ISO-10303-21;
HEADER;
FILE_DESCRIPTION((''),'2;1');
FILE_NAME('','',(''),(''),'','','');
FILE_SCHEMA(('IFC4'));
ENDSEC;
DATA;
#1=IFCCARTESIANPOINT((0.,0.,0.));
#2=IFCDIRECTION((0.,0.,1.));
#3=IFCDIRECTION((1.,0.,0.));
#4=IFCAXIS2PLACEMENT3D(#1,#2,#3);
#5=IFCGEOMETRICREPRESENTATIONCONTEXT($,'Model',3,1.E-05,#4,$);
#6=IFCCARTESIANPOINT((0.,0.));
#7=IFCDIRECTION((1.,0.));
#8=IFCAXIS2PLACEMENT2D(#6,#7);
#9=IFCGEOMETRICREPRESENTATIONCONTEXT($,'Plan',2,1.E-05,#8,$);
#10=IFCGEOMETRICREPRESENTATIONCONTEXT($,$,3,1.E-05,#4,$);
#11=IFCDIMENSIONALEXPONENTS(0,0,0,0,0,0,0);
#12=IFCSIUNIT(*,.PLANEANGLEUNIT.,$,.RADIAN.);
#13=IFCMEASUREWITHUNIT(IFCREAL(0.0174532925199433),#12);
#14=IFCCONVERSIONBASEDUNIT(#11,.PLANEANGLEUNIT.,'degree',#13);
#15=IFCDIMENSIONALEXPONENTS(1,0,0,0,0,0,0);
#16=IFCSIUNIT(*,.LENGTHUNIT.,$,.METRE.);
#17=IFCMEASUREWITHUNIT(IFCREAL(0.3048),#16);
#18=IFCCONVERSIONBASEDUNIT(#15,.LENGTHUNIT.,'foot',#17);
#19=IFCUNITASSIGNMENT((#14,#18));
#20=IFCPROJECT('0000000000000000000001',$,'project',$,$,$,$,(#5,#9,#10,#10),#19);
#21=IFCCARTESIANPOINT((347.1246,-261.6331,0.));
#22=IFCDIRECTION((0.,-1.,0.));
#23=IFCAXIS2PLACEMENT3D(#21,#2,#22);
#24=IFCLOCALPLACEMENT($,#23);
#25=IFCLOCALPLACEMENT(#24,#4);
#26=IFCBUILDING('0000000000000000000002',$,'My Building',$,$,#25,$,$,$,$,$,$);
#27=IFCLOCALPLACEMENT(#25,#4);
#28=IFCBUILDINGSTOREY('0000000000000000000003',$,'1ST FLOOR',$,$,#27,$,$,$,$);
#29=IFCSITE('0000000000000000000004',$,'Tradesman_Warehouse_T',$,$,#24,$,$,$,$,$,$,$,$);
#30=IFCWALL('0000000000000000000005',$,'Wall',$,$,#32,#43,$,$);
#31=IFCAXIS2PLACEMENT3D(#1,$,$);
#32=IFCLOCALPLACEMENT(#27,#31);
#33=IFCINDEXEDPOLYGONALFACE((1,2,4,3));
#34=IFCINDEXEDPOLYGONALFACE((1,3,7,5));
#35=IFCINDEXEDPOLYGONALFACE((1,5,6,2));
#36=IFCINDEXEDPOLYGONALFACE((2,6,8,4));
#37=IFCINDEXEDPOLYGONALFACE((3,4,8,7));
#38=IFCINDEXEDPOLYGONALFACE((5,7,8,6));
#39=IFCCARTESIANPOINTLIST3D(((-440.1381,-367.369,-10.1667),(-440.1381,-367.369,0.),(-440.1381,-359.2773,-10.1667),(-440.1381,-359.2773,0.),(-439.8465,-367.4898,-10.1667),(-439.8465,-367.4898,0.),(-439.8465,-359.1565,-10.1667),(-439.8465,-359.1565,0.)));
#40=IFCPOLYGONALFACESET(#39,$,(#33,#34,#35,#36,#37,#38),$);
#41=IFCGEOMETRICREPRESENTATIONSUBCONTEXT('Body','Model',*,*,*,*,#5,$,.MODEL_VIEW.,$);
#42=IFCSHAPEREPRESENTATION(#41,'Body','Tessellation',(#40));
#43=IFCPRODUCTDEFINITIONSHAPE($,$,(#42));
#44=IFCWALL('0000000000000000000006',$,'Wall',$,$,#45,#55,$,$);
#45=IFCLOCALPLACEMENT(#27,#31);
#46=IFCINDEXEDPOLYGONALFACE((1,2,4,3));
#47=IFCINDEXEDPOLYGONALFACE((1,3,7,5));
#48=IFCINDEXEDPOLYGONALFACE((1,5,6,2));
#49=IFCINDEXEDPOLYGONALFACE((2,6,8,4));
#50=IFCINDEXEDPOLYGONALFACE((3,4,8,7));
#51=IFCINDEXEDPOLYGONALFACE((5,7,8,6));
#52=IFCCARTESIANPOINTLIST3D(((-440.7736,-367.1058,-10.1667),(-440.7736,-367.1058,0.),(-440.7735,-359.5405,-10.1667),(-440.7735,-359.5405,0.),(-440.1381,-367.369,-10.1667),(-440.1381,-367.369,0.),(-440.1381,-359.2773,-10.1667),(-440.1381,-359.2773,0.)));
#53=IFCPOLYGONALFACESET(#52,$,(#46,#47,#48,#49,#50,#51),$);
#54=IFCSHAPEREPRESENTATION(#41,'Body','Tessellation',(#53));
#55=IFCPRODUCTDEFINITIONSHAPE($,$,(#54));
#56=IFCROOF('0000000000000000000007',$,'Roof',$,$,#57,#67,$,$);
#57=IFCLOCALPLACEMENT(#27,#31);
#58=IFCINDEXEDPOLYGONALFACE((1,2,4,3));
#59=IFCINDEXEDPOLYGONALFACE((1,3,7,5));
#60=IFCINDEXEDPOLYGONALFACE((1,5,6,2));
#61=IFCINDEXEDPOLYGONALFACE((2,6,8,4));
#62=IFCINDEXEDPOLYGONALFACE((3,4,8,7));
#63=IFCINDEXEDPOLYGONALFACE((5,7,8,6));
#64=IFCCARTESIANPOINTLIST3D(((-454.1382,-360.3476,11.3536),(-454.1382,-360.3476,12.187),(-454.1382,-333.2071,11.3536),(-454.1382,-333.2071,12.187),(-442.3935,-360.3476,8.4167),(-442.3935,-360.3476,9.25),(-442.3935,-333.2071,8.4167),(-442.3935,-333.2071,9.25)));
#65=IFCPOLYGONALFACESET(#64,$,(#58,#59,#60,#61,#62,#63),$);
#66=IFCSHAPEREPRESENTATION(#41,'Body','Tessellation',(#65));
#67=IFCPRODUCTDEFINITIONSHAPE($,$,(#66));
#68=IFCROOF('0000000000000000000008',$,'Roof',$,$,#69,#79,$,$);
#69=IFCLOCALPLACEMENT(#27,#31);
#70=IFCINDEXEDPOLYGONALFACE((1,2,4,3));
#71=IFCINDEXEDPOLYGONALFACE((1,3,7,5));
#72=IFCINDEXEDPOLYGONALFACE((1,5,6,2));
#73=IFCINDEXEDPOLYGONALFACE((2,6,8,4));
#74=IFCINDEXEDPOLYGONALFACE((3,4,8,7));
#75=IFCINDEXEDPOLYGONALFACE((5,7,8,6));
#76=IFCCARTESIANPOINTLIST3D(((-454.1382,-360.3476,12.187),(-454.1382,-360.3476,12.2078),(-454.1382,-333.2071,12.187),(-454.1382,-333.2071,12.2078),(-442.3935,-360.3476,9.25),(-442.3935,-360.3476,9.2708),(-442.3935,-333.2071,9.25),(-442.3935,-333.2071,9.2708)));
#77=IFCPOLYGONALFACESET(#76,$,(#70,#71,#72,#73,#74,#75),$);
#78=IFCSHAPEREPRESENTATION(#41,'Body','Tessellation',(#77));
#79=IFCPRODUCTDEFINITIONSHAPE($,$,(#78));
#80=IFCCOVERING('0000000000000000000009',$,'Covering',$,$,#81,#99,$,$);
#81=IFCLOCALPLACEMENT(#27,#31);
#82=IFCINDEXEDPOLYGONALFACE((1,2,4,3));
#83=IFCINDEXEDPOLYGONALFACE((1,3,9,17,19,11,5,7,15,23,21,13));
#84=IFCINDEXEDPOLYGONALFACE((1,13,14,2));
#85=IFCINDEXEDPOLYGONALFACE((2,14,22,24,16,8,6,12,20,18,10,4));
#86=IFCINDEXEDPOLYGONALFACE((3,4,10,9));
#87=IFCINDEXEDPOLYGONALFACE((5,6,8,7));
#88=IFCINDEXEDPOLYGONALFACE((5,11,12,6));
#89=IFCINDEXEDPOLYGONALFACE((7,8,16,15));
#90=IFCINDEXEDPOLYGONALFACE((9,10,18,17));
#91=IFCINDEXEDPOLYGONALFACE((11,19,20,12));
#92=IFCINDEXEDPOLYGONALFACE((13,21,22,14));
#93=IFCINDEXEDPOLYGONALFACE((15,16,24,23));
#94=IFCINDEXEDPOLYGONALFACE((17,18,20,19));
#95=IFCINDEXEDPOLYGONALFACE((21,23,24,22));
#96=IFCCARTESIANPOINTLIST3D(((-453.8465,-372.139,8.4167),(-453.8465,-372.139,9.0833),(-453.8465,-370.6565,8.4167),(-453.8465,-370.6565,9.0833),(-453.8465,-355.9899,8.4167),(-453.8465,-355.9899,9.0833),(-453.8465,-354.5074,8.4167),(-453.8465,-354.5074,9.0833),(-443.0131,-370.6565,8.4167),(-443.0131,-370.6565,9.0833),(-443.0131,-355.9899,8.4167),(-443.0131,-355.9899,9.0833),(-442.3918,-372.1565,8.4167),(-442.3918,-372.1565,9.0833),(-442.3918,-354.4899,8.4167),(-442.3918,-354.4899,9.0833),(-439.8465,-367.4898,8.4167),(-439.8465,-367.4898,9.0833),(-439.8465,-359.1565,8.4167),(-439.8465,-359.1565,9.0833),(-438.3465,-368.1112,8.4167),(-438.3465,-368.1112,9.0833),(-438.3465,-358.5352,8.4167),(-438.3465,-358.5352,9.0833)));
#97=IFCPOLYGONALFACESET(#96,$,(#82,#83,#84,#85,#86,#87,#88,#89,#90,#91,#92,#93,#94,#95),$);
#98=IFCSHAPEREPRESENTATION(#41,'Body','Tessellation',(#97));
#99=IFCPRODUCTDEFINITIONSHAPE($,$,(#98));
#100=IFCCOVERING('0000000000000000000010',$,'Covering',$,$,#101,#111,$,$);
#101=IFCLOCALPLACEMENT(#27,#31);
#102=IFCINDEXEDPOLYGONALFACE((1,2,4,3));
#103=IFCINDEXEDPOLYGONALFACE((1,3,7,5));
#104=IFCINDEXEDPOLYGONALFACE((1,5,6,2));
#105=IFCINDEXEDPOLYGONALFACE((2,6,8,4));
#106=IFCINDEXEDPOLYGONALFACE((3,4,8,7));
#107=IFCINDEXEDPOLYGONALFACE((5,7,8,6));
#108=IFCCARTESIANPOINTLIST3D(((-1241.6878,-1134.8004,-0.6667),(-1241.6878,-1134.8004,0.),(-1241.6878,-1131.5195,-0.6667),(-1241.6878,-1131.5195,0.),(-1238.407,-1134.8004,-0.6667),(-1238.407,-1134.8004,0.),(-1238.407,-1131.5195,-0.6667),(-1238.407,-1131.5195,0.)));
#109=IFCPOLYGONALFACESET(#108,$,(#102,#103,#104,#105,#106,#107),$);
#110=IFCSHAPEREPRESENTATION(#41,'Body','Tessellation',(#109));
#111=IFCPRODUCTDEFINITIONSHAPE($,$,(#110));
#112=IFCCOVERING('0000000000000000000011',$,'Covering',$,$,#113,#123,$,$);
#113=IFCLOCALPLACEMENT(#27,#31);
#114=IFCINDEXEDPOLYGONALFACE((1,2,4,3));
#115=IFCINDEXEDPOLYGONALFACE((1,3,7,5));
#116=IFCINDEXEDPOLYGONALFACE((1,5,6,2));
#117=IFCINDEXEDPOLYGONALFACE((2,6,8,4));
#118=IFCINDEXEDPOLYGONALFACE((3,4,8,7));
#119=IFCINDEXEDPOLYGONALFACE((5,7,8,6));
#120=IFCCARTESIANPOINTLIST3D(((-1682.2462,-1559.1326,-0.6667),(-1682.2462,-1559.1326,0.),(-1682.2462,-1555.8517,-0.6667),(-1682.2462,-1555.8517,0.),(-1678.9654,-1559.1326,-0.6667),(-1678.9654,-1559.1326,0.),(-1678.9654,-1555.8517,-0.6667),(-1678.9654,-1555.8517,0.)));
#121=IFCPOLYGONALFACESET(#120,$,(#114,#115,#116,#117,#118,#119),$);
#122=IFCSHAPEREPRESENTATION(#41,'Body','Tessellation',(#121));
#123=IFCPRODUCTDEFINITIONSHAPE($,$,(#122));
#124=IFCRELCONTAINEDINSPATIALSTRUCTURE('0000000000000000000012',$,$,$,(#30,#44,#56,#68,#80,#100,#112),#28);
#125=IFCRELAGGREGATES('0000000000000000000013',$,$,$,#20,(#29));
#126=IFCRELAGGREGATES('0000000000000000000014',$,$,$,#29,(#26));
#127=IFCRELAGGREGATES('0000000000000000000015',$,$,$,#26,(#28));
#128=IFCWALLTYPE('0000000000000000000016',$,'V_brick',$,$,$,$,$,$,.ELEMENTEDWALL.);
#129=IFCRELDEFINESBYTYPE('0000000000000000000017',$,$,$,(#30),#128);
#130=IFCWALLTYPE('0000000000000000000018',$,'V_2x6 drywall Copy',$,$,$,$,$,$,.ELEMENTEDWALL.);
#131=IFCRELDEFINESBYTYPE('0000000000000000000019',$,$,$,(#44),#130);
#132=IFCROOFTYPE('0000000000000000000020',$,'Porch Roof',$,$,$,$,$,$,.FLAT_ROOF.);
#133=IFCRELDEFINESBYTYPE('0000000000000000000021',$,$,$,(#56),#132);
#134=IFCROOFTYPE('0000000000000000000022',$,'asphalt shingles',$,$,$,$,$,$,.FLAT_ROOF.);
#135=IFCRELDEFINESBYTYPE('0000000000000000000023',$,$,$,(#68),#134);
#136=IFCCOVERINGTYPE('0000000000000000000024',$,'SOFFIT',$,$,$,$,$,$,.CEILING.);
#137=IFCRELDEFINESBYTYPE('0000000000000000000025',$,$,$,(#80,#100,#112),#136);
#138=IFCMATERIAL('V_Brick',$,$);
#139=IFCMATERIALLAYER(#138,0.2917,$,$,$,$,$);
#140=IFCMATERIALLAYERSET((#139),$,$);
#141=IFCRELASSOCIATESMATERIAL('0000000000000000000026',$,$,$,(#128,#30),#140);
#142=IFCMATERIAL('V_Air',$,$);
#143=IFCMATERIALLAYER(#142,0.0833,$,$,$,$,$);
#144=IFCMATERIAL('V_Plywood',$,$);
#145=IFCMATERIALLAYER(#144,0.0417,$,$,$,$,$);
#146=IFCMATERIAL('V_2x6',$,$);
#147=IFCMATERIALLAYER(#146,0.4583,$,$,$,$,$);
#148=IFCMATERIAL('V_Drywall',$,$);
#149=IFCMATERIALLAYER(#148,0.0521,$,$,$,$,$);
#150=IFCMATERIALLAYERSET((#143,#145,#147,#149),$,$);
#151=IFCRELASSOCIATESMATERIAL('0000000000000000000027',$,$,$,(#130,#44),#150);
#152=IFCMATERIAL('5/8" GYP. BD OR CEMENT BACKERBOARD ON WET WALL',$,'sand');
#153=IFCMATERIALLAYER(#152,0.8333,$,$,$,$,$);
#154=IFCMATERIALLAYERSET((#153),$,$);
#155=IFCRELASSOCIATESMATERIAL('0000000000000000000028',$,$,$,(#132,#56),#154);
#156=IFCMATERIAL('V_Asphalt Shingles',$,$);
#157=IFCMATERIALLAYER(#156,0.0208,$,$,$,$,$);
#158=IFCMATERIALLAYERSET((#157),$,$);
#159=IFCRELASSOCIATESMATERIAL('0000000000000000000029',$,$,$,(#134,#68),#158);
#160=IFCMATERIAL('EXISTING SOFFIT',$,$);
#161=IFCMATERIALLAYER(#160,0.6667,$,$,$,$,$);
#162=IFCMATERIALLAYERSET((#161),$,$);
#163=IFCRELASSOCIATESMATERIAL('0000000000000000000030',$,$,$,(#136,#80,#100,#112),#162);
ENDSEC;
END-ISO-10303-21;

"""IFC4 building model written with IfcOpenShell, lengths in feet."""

from ifc_helpers import new_model, entity, si_unit, converted_unit, frame, origin_with_axes, origin_2d_with_axis, place, context, subcontext, project, spatial, indexed_curve, outline, extrude, clip, halfspace, material, layer, layer_set, layer_usage, type_object, element, save


model = new_model("IFC4")

# Units and contexts
model_context = context("Model", 3, precision=1e-05, world=origin_with_axes())
plan_context = context("Plan", 2, precision=1e-05, world=origin_2d_with_axis())
context_of_model = context(None, 3, precision=1e-05, world=origin_with_axes())
body_context = subcontext(model_context, "Body", "Model", "MODEL_VIEW")
ifc_project = project(units=[converted_unit("PLANEANGLEUNIT", "degree", entity("IfcReal", 0.0174532925199433), si_unit("PLANEANGLEUNIT", "RADIAN"), dimensions=[0, 0, 0, 0, 0, 0, 0]), converted_unit("LENGTHUNIT", "foot", entity("IfcReal", 0.3048), si_unit("LENGTHUNIT", "METRE"), dimensions=[1, 0, 0, 0, 0, 0, 0])], contexts=[model_context, plan_context, context_of_model, context_of_model])

# Site, building, storey
site_placement = place(None, frame((347.1246, -261.6331, 0.0), z_axis=(0.0, 0.0, 1.0), x_axis=(0.0, -1.0, 0.0)))
site = spatial("IfcSite", under=ifc_project, at=site_placement, Name="Tradesman_Warehouse_T")
building_placement = place(site_placement, frame((0.0, 0.0, 0.0), z_axis=(0.0, 0.0, 1.0), x_axis=(1.0, 0.0, 0.0)))
building = spatial("IfcBuilding", under=site, at=building_placement, Name="My Building")
storey_placement = place(building_placement, frame((0.0, 0.0, 0.0), z_axis=(0.0, 0.0, 1.0), x_axis=(1.0, 0.0, 0.0)))
storey = spatial("IfcBuildingStorey", under=building, at=storey_placement, Name="1ST FLOOR")

# Shared definitions
ifc_material_1 = material(Name="V_Brick")
ifc_layer_1 = layer(ifc_material_1, 0.2917)
ifc_layer_set_1 = layer_set([ifc_layer_1])
wall_type_1 = type_object("IfcWallType", Name="V_brick", PredefinedType="ELEMENTEDWALL", material=ifc_layer_set_1)

# Wall
ifc_layer_usage_1 = layer_usage(ifc_layer_set_1, "AXIS2", "POSITIVE", 0.0)
wall_1_placement = place(storey_placement, frame((-439.8465, -367.7815, -10.1667), z_axis=(0.0, 0.0, 1.0), x_axis=(0.0, 1.0, 0.0)))
element("IfcWall", 1, at=wall_1_placement, inside=storey, type_object=wall_type_1, material=ifc_layer_usage_1, Name="Wall", context=body_context, shape_type="Clipping", body=[
    clip(clip(extrude(outline(indexed_curve([(0.0, 0.0), (0.0, 0.2917), (8.9166, 0.2917), (8.9166, 0.0), (0.0, 0.0)], self_intersect=False)), origin_with_axes(), (0.0, 0.0, 1.0), 10.1667), halfspace(frame((8.625, 0.0, 10.1667), z_axis=(0.923917, 0.382594, 0.0), x_axis=(0.382594, -0.923917, 0.0)), False)), halfspace(frame((0.2917, 0.0, 10.1667), z_axis=(-0.923891, 0.382655, 0.0), x_axis=(0.382655, 0.923891, 0.0)), False)),
])

# Shared definitions
ifc_material_2 = material(Name="V_Air")
ifc_layer_2 = layer(ifc_material_2, 0.0833)
ifc_material_3 = material(Name="V_Plywood")
ifc_layer_3 = layer(ifc_material_3, 0.0417)
ifc_material_4 = material(Name="V_2x6")
ifc_layer_4 = layer(ifc_material_4, 0.4583)
ifc_material_5 = material(Name="V_Drywall")
ifc_layer_5 = layer(ifc_material_5, 0.0521)
ifc_layer_set_2 = layer_set([ifc_layer_2, ifc_layer_3, ifc_layer_4, ifc_layer_5])
wall_type_2 = type_object("IfcWallType", Name="V_2x6 drywall Copy", PredefinedType="ELEMENTEDWALL", material=ifc_layer_set_2)

# Wall
ifc_layer_usage_2 = layer_usage(ifc_layer_set_2, "AXIS2", "POSITIVE", 0.0)
wall_2_placement = place(storey_placement, frame((-440.1381, -368.0044, -10.1667), z_axis=(0.0, 0.0, 1.0), x_axis=(0.0, 1.0, 0.0)))
element("IfcWall", 2, at=wall_2_placement, inside=storey, type_object=wall_type_2, material=ifc_layer_usage_2, Name="Wall", context=body_context, shape_type="Clipping", body=[
    clip(clip(extrude(outline(indexed_curve([(0.0, 0.0), (0.0, 0.6354), (9.3625, 0.6354), (9.3625, 0.0), (0.0, 0.0)], self_intersect=False)), origin_with_axes(), (0.0, 0.0, 1.0), 10.1667), halfspace(frame((0.6354, 0.0, 10.1667), z_axis=(-0.923881, 0.382681, 0.0), x_axis=(0.382681, 0.923881, 0.0)), False)), halfspace(frame((8.7271, 0.0, 10.1667), z_axis=(0.92388, 0.382683, 0.0), x_axis=(0.382683, -0.92388, 0.0)), False)),
])

# Roofs
ifc_material_6 = material(Name="5/8\" GYP. BD OR CEMENT BACKERBOARD ON WET WALL", Category="sand")
ifc_layer_6 = layer(ifc_material_6, 0.8333)
ifc_layer_set_3 = layer_set([ifc_layer_6])
ifc_layer_usage_3 = layer_usage(ifc_layer_set_3, "AXIS3", "POSITIVE", 0.0)
roof_type_1 = type_object("IfcRoofType", Name="Porch Roof", PredefinedType="FLAT_ROOF", material=ifc_layer_set_3)
roof_1_placement = place(storey_placement, frame((-454.1381, -360.3476, 11.3536), z_axis=(0.242599, 0.0, 0.970127), x_axis=(0.0, -1.0, 0.0)))
element("IfcRoof", 3, at=roof_1_placement, inside=storey, type_object=roof_type_1, material=ifc_layer_usage_3, Name="Roof", context=body_context, shape_type="SweptSolid", body=[
    extrude(outline(indexed_curve([(0.0, 0.0), (0.0, 12.1063), (-27.1405, 12.1063), (-27.1405, 0.0), (0.0, 0.0)])), None, (0.0, -0.242599, 0.970127), 0.8333),
])
ifc_material_7 = material(Name="V_Asphalt Shingles")
ifc_layer_7 = layer(ifc_material_7, 0.0208)
ifc_layer_set_4 = layer_set([ifc_layer_7])
ifc_layer_usage_4 = layer_usage(ifc_layer_set_4, "AXIS3", "POSITIVE", 0.0)
roof_type_2 = type_object("IfcRoofType", Name="asphalt shingles", PredefinedType="FLAT_ROOF", material=ifc_layer_set_4)
roof_2_placement = place(storey_placement, frame((-454.1381, -360.3476, 12.187), z_axis=(0.242599, 0.0, 0.970127), x_axis=(0.0, -1.0, 0.0)))
element("IfcRoof", 4, at=roof_2_placement, inside=storey, type_object=roof_type_2, material=ifc_layer_usage_4, Name="Roof", context=body_context, shape_type="SweptSolid", body=[
    extrude(outline(indexed_curve([(-27.1405, 0.0), (0.0, 0.0), (0.0, 12.1063), (-27.1405, 12.1063), (-27.1405, 0.0)])), None, (0.0, -0.242599, 0.970127), 0.0208),
])

# Coverings
ifc_material_8 = material(Name="EXISTING SOFFIT")
ifc_layer_8 = layer(ifc_material_8, 0.6667)
ifc_layer_set_5 = layer_set([ifc_layer_8])
ifc_layer_usage_5 = layer_usage(ifc_layer_set_5, "AXIS3", "POSITIVE", 0.0)
covering_type = type_object("IfcCoveringType", Name="SOFFIT", PredefinedType="CEILING", material=ifc_layer_set_5)
covering_1_placement = place(storey_placement, frame((-438.3465, -368.1112, 8.4167), z_axis=(0.0, 0.0, 1.0), x_axis=(0.0, 1.0, 0.0)))
element("IfcCovering", 5, at=covering_1_placement, inside=storey, type_object=covering_type, material=ifc_layer_usage_5, Name="Covering", context=body_context, shape_type="SweptSolid", body=[
    extrude(outline(indexed_curve([(13.6038, 15.5), (12.1213, 15.5), (12.1213, 4.6667), (8.9546, 1.5), (0.6213, 1.5), (-2.5454, 4.6667), (-2.5454, 15.5), (-4.0279, 15.5), (-4.0454, 4.0454), (0.0, 0.0), (9.5759, 0.0), (13.6213, 4.0453), (13.6038, 15.5)])), None, (0.0, 0.0, 1.0), 0.6667),
])
ifc_layer_usage_6 = layer_usage(ifc_layer_set_5, "AXIS3", "POSITIVE", 0.0)
covering_2_placement = place(storey_placement, frame((-1238.407, -1134.8004, -0.6667), z_axis=(0.0, 0.0, 1.0), x_axis=(0.0, 1.0, 0.0)))
element("IfcCovering", 6, at=covering_2_placement, inside=storey, type_object=covering_type, material=ifc_layer_usage_6, Name="Covering", context=body_context, shape_type="SweptSolid", body=[
    extrude(outline(indexed_curve([(0.0, 0.0), (3.2808, 0.0), (3.2808, 3.2808), (0.0, 3.2808), (0.0, 0.0)])), None, (0.0, 0.0, 1.0), 0.6667),
])
ifc_layer_usage_7 = layer_usage(ifc_layer_set_5, "AXIS3", "POSITIVE", 0.0)
covering_3_placement = place(storey_placement, frame((-1678.9654, -1559.1326, -0.6667), z_axis=(0.0, 0.0, 1.0), x_axis=(0.0, 1.0, 0.0)))
element("IfcCovering", 7, at=covering_3_placement, inside=storey, type_object=covering_type, material=ifc_layer_usage_7, Name="Covering", context=body_context, shape_type="SweptSolid", body=[
    extrude(outline(indexed_curve([(0.0, 0.0), (3.2808, 0.0), (3.2808, 3.2808), (0.0, 3.2808), (0.0, 0.0)])), None, (0.0, 0.0, 1.0), 0.6667),
])

save(model, "model.ifc")
